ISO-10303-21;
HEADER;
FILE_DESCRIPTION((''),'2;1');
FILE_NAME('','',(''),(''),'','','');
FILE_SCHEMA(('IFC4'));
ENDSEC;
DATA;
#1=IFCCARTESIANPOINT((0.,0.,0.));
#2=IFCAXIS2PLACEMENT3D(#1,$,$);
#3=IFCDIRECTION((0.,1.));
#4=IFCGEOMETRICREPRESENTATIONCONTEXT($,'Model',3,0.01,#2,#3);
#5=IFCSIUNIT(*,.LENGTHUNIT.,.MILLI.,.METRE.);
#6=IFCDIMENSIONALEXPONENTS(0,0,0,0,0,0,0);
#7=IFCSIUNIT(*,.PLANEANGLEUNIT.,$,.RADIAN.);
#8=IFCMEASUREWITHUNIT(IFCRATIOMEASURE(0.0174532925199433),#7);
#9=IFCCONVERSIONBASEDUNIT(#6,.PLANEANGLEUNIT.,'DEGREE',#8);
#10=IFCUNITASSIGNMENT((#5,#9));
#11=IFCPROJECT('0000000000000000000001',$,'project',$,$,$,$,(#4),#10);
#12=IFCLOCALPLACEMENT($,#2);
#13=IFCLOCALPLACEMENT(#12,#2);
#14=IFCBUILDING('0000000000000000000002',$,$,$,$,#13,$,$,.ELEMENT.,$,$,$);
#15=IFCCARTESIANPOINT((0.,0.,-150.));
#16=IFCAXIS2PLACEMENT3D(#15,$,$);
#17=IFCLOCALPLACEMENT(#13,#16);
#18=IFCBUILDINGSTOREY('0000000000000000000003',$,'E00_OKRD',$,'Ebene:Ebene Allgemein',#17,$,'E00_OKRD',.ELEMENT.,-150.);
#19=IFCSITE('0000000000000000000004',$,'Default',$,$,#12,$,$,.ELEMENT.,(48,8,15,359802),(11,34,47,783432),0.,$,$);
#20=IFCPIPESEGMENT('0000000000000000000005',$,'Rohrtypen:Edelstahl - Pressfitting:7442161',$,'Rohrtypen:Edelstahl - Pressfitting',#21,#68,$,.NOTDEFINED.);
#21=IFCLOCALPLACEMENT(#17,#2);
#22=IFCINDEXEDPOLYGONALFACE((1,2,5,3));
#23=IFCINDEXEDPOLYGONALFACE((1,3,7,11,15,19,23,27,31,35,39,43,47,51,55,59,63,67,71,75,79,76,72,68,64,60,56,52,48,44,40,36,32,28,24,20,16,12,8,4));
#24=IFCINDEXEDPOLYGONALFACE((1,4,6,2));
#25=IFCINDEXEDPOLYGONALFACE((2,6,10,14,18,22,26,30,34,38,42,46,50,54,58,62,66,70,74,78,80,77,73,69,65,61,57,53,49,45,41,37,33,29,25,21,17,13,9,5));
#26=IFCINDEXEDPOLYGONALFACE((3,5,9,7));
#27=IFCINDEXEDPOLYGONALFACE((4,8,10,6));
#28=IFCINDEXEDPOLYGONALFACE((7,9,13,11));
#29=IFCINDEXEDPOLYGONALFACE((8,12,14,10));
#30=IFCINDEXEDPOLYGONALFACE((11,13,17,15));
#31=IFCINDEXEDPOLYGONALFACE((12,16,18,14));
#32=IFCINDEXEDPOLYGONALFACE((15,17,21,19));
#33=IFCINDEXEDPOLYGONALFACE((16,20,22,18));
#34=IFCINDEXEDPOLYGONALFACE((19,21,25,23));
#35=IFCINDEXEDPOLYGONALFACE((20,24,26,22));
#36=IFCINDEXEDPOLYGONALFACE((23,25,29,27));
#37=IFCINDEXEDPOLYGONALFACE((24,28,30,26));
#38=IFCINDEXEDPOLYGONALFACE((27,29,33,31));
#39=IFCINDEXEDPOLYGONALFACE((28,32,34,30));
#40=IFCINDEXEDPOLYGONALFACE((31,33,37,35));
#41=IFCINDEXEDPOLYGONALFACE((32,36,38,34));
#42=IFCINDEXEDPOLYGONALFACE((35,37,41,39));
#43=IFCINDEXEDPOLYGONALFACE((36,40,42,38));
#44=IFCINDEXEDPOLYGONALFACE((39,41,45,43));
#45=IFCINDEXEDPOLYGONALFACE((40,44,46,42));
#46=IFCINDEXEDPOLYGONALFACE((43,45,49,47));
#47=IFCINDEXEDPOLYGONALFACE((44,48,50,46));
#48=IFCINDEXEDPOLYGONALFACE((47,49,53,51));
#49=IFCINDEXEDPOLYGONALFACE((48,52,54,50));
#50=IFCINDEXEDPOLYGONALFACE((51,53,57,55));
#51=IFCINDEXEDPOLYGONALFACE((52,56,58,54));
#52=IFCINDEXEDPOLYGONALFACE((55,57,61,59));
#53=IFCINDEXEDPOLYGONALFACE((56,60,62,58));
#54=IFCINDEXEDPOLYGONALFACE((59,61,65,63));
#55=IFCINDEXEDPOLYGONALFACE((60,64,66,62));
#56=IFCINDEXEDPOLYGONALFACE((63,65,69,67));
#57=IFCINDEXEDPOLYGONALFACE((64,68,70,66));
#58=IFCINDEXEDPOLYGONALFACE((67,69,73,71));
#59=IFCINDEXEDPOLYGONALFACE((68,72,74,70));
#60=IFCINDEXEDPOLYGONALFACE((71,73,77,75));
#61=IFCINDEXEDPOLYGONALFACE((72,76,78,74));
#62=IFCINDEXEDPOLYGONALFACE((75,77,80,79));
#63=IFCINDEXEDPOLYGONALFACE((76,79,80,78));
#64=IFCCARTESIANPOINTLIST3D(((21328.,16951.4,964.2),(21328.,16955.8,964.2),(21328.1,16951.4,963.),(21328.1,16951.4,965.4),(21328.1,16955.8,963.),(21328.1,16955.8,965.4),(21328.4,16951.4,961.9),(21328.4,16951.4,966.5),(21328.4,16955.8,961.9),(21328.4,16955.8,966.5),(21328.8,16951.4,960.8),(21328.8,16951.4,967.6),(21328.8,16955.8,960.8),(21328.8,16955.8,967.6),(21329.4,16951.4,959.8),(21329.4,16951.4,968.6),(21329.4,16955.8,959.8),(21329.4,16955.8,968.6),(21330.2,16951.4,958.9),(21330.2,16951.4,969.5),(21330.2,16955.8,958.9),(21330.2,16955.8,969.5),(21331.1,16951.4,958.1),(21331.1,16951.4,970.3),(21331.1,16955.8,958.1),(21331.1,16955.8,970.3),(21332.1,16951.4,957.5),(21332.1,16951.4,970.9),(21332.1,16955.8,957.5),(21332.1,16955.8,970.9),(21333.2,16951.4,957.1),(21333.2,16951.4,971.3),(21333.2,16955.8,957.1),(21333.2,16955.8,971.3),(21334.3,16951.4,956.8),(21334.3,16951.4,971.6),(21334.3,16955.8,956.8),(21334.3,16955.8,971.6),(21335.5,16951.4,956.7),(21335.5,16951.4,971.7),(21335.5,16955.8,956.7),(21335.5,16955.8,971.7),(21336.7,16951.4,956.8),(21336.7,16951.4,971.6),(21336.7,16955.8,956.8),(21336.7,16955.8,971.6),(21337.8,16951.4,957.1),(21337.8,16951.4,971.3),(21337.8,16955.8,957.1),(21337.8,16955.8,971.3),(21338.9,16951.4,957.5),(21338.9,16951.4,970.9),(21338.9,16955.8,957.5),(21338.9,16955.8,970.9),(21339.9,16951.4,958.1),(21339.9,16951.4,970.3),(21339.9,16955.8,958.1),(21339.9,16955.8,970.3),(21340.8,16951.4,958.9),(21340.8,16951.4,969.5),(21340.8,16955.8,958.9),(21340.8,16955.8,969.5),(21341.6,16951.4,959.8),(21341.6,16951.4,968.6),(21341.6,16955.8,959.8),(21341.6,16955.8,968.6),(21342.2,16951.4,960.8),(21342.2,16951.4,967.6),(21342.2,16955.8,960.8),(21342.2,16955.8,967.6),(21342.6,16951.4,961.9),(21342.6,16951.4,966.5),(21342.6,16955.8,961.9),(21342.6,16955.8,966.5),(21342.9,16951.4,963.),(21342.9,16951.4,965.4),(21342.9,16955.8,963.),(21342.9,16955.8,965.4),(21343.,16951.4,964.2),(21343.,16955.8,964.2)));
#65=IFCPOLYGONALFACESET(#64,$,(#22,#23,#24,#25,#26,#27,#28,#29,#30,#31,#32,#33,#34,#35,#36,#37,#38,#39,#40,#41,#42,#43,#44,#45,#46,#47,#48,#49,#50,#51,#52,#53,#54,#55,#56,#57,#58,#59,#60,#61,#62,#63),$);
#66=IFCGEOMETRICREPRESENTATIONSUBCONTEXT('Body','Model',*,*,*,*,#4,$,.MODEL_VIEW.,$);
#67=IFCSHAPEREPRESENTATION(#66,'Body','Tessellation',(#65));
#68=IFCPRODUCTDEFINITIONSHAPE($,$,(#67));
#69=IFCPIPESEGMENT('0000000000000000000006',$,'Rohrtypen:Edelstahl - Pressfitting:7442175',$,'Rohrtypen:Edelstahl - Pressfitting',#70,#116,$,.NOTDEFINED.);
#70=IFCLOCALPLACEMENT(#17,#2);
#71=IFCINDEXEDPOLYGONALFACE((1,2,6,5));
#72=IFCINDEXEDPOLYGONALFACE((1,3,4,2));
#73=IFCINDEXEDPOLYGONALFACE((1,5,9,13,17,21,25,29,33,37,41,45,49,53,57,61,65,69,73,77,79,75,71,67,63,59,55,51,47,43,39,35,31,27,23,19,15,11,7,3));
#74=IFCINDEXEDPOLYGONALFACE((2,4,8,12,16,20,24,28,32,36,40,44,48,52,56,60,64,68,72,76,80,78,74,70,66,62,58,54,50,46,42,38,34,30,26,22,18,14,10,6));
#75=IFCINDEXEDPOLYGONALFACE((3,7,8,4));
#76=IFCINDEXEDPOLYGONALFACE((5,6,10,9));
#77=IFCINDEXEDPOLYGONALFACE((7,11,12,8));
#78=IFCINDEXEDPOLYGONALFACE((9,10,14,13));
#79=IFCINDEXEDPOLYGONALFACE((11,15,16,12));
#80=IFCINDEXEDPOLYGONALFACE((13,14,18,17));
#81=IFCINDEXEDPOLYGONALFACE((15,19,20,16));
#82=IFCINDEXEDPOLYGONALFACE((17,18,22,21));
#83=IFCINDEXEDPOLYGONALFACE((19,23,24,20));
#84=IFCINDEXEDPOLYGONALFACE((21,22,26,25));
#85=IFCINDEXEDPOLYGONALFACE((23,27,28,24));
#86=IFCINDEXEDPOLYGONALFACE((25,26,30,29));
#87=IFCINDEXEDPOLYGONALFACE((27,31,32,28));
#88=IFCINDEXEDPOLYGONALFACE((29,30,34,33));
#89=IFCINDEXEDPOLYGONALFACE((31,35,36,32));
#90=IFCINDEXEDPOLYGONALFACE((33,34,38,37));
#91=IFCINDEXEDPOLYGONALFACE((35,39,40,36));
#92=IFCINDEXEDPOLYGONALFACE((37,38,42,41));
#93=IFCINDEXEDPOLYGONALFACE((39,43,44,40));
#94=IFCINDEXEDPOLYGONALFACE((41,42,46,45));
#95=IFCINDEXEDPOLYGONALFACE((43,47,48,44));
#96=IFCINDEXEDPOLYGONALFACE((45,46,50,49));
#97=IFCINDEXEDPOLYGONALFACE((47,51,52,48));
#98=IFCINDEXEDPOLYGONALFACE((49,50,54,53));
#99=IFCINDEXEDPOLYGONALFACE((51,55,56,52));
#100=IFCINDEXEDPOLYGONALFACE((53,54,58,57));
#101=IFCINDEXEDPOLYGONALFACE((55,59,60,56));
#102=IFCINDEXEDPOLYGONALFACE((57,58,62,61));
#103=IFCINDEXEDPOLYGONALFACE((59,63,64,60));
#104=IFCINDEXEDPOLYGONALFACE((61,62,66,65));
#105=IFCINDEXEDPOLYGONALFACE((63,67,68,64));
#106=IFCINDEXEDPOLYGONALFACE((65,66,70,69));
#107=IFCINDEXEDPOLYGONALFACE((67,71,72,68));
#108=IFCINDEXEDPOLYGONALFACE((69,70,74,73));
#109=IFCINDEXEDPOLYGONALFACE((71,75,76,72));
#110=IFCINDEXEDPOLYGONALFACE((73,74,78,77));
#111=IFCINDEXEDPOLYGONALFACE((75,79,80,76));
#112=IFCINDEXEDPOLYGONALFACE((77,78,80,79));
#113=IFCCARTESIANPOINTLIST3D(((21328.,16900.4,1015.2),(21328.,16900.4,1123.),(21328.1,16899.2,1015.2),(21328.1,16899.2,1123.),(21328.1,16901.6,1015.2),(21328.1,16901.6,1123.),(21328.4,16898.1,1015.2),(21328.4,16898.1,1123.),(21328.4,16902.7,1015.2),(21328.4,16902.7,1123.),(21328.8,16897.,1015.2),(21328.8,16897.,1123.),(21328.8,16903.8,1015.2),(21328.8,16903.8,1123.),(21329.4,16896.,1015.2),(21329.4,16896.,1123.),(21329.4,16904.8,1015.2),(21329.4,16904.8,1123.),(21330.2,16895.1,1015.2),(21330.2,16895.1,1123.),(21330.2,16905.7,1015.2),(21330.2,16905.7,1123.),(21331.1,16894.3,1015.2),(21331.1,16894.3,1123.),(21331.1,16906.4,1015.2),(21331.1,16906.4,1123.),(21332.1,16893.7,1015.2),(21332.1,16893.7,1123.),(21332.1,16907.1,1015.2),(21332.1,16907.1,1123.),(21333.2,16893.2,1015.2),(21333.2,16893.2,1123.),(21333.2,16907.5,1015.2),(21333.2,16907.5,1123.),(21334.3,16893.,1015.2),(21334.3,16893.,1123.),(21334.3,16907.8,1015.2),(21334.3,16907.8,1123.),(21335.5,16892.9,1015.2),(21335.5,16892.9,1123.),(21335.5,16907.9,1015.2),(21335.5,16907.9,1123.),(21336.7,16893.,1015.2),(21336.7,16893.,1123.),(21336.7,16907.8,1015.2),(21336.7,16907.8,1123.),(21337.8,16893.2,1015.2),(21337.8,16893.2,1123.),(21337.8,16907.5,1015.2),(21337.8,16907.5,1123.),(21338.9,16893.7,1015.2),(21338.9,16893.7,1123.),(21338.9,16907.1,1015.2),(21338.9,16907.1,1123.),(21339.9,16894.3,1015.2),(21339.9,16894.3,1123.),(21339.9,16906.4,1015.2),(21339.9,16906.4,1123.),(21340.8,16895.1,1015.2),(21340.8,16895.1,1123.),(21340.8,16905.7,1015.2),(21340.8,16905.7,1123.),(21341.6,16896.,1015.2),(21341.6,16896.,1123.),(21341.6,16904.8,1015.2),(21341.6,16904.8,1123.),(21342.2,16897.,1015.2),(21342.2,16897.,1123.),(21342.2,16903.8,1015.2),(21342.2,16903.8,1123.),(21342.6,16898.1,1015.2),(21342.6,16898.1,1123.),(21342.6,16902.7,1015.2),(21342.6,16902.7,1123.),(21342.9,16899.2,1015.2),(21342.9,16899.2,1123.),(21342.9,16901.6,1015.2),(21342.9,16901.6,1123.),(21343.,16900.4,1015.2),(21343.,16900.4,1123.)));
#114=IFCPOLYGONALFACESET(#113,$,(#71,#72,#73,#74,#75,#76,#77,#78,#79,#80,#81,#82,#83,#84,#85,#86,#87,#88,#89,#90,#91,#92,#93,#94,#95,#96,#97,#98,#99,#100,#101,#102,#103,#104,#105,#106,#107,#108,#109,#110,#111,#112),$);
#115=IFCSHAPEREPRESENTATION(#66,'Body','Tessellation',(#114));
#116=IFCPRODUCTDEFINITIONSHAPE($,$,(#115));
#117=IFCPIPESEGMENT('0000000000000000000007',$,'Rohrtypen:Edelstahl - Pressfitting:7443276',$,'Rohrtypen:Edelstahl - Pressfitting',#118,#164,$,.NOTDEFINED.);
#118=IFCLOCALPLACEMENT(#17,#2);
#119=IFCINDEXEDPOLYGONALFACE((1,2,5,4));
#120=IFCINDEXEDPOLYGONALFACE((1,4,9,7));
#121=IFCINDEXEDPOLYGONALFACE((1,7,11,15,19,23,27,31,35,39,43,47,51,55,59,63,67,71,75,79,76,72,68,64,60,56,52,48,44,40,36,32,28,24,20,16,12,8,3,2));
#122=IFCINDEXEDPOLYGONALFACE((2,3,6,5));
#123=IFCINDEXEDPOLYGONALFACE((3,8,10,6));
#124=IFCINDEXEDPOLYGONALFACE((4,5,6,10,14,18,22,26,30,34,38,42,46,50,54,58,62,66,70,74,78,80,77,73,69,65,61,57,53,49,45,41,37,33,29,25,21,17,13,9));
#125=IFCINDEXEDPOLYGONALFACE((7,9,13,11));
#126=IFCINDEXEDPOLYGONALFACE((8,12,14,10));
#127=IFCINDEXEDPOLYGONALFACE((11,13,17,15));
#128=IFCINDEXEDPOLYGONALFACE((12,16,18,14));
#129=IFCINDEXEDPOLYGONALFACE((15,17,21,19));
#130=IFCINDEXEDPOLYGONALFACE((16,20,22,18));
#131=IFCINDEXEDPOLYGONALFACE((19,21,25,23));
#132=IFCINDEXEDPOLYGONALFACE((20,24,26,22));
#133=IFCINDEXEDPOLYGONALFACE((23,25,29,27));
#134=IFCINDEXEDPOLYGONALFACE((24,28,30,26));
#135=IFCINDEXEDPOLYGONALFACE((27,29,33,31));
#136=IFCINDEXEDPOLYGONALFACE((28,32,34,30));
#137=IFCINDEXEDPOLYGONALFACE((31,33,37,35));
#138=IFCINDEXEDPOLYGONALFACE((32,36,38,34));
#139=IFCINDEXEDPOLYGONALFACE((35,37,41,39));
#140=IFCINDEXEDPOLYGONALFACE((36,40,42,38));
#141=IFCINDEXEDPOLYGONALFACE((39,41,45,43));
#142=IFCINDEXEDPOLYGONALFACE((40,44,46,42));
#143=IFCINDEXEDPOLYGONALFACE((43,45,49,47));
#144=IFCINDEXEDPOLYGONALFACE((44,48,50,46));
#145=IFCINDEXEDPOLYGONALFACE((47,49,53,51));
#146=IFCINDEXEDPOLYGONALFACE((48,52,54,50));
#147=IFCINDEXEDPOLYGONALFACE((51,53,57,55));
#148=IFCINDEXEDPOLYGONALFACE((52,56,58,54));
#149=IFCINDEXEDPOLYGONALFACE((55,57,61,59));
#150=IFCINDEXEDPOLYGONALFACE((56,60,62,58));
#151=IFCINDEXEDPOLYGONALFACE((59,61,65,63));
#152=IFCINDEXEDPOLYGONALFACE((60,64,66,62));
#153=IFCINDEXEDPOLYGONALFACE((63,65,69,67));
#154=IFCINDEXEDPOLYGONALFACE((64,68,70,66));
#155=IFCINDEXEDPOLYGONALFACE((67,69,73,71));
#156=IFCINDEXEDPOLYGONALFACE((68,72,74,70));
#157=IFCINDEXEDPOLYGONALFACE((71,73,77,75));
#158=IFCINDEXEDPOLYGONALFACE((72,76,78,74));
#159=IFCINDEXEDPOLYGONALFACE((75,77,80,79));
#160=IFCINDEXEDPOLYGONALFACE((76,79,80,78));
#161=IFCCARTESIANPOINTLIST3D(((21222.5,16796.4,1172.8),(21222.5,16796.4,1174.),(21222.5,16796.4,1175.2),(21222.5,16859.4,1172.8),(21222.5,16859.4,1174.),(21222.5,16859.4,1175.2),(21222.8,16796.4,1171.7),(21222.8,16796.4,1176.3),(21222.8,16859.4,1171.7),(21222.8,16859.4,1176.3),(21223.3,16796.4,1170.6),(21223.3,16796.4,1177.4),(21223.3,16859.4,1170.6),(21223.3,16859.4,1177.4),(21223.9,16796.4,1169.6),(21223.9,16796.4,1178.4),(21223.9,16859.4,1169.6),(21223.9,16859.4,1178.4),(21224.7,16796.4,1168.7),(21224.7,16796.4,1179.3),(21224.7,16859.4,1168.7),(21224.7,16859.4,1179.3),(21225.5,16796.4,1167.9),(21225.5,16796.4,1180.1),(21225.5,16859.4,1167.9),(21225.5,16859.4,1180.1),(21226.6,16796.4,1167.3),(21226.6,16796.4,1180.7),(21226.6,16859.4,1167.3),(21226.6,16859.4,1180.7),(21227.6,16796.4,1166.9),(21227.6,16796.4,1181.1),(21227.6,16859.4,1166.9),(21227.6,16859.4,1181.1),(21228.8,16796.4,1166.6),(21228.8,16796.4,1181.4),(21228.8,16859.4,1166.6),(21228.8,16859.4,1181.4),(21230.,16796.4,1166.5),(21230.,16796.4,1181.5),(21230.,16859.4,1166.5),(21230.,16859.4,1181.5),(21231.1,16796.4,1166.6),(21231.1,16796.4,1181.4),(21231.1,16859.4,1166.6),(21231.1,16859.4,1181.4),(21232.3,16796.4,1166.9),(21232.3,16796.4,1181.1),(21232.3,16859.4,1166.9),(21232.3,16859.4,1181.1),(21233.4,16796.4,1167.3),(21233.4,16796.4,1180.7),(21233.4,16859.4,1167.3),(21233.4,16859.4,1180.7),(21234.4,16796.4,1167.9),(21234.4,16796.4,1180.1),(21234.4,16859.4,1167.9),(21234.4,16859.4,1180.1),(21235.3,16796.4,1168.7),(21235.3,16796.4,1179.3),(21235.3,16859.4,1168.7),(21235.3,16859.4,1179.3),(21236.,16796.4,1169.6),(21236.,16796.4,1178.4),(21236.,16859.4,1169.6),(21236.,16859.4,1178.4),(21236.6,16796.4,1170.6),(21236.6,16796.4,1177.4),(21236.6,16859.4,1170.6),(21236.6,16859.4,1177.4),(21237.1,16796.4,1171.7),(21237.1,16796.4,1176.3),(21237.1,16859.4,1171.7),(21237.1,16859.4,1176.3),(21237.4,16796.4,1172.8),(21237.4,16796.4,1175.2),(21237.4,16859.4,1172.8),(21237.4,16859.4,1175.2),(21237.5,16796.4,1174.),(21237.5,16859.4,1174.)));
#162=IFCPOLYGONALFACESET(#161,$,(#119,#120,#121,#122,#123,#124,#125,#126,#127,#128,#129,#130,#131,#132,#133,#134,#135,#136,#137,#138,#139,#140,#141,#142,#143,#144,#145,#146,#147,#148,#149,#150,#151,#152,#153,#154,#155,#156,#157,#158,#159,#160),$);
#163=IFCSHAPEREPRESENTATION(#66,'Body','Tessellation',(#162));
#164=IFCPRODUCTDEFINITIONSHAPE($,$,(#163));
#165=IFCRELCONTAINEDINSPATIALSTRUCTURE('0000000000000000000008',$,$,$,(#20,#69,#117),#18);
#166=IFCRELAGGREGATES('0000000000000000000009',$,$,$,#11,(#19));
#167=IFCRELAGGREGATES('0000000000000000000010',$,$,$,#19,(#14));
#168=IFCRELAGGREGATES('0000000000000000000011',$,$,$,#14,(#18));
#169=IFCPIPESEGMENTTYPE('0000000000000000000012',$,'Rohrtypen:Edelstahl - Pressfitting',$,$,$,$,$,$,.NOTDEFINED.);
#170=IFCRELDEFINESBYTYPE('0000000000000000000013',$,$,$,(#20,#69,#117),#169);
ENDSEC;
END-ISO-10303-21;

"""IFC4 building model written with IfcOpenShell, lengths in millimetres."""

from ifc_helpers import new_model, entity, si_unit, converted_unit, direction, frame, origin, place, context, subcontext, project, spatial, indexed_curve, outline, extrude, type_object, element, save


model = new_model("IFC4")

# Units and contexts
model_context = context("Model", 3, precision=0.01, world=origin(), true_north=direction((0.0, 1.0)))
body_context = subcontext(model_context, "Body", "Model", "MODEL_VIEW")
ifc_project = project(units=[si_unit("LENGTHUNIT", "METRE", prefix="MILLI"), converted_unit("PLANEANGLEUNIT", "DEGREE", entity("IfcRatioMeasure", 0.0174532925199433), si_unit("PLANEANGLEUNIT", "RADIAN"), dimensions=[0, 0, 0, 0, 0, 0, 0])], contexts=[model_context])

# Site, building, storey
site_placement = place(None, origin())
site = spatial("IfcSite", under=ifc_project, at=site_placement, Name="Default", CompositionType="ELEMENT", RefLatitude=(48, 8, 15, 359802), RefLongitude=(11, 34, 47, 783432), RefElevation=0.0)
building_placement = place(site_placement, origin())
building = spatial("IfcBuilding", under=site, at=building_placement, CompositionType="ELEMENT")
storey_placement = place(building_placement, frame((0.0, 0.0, -150.0)))
storey = spatial("IfcBuildingStorey", under=building, at=storey_placement, Name="E00_OKRD", ObjectType="Ebene:Ebene Allgemein", LongName="E00_OKRD", CompositionType="ELEMENT", Elevation=-150.0)

# Pipe segments
pipe_segment_type_1 = type_object("IfcPipeSegmentType", Name="Rohrtypen:Edelstahl - Pressfitting", PredefinedType="NOTDEFINED")
pipe_segment_1_placement = place(storey_placement, origin())
element("IfcPipeSegment", 1, at=pipe_segment_1_placement, inside=storey, type_object=pipe_segment_type_1, Name="Rohrtypen:Edelstahl - Pressfitting:7442161", ObjectType="Rohrtypen:Edelstahl - Pressfitting", PredefinedType="NOTDEFINED", context=body_context, shape_type="SweptSolid", body=[
    extrude(outline(indexed_curve([(7.5, 0.0), (7.4, 1.2), (7.1, 2.3), (6.7, 3.4), (6.1, 4.4), (5.3, 5.3), (4.4, 6.1), (3.4, 6.7), (2.3, 7.1), (1.2, 7.4), (0.0, 7.5), (-1.2, 7.4), (-2.3, 7.1), (-3.4, 6.7), (-4.4, 6.1), (-5.3, 5.3), (-6.1, 4.4), (-6.7, 3.4), (-7.1, 2.3), (-7.4, 1.2), (-7.5, 0.0), (-7.4, -1.2), (-7.1, -2.3), (-6.7, -3.4), (-6.1, -4.4), (-5.3, -5.3), (-4.4, -6.1), (-3.4, -6.7), (-2.3, -7.1), (-1.2, -7.4), (0.0, -7.5), (1.2, -7.4), (2.3, -7.1), (3.4, -6.7), (4.4, -6.1), (5.3, -5.3), (6.1, -4.4), (6.7, -3.4), (7.1, -2.3), (7.4, -1.2), (7.5, 0.0)], self_intersect=False)), frame((21335.5, 16951.4, 964.2), z_axis=(0.0, 1.0, 0.0), x_axis=(-1.0, 0.0, 0.0)), (0.0, 0.0, 1.0), 4.4),
])
pipe_segment_2_placement = place(storey_placement, origin())
element("IfcPipeSegment", 2, at=pipe_segment_2_placement, inside=storey, type_object=pipe_segment_type_1, Name="Rohrtypen:Edelstahl - Pressfitting:7442175", ObjectType="Rohrtypen:Edelstahl - Pressfitting", PredefinedType="NOTDEFINED", context=body_context, shape_type="SweptSolid", body=[
    extrude(outline(indexed_curve([(7.5, 0.0), (7.4, 1.2), (7.1, 2.3), (6.7, 3.4), (6.1, 4.4), (5.3, 5.3), (4.4, 6.1), (3.4, 6.7), (2.3, 7.1), (1.2, 7.4), (0.0, 7.5), (-1.2, 7.4), (-2.3, 7.1), (-3.4, 6.7), (-4.4, 6.1), (-5.3, 5.3), (-6.1, 4.4), (-6.7, 3.4), (-7.1, 2.3), (-7.4, 1.2), (-7.5, 0.0), (-7.4, -1.2), (-7.1, -2.3), (-6.7, -3.4), (-6.1, -4.4), (-5.3, -5.3), (-4.4, -6.1), (-3.4, -6.7), (-2.3, -7.1), (-1.2, -7.4), (0.0, -7.5), (1.2, -7.4), (2.3, -7.1), (3.4, -6.7), (4.4, -6.1), (5.3, -5.3), (6.1, -4.4), (6.7, -3.4), (7.1, -2.3), (7.4, -1.2), (7.5, 0.0)], self_intersect=False)), frame((21335.5, 16900.4, 1015.2), z_axis=(0.0, 0.0, 1.0), x_axis=(-1.0, 0.0, 0.0)), (0.0, 0.0, 1.0), 107.8),
])
pipe_segment_3_placement = place(storey_placement, origin())
element("IfcPipeSegment", 3, at=pipe_segment_3_placement, inside=storey, type_object=pipe_segment_type_1, Name="Rohrtypen:Edelstahl - Pressfitting:7443276", ObjectType="Rohrtypen:Edelstahl - Pressfitting", PredefinedType="NOTDEFINED", context=body_context, shape_type="SweptSolid", body=[
    extrude(outline(indexed_curve([(7.5, 0.0), (7.4, 1.2), (7.1, 2.3), (6.7, 3.4), (6.1, 4.4), (5.3, 5.3), (4.4, 6.1), (3.4, 6.7), (2.3, 7.1), (1.2, 7.4), (0.0, 7.5), (-1.2, 7.4), (-2.3, 7.1), (-3.4, 6.7), (-4.4, 6.1), (-5.3, 5.3), (-6.1, 4.4), (-6.7, 3.4), (-7.1, 2.3), (-7.4, 1.2), (-7.5, 0.0), (-7.4, -1.2), (-7.1, -2.3), (-6.7, -3.4), (-6.1, -4.4), (-5.3, -5.3), (-4.4, -6.1), (-3.4, -6.7), (-2.3, -7.1), (-1.2, -7.4), (0.0, -7.5), (1.2, -7.4), (2.3, -7.1), (3.4, -6.7), (4.4, -6.1), (5.3, -5.3), (6.1, -4.4), (6.7, -3.4), (7.1, -2.3), (7.4, -1.2), (7.5, 0.0)], self_intersect=False)), frame((21230.0, 16796.4, 1174.0), z_axis=(0.0, 1.0, 0.0), x_axis=(-1.0, 0.0, 0.0)), (0.0, 0.0, 1.0), 63.0),
])

save(model, "model.ifc")
